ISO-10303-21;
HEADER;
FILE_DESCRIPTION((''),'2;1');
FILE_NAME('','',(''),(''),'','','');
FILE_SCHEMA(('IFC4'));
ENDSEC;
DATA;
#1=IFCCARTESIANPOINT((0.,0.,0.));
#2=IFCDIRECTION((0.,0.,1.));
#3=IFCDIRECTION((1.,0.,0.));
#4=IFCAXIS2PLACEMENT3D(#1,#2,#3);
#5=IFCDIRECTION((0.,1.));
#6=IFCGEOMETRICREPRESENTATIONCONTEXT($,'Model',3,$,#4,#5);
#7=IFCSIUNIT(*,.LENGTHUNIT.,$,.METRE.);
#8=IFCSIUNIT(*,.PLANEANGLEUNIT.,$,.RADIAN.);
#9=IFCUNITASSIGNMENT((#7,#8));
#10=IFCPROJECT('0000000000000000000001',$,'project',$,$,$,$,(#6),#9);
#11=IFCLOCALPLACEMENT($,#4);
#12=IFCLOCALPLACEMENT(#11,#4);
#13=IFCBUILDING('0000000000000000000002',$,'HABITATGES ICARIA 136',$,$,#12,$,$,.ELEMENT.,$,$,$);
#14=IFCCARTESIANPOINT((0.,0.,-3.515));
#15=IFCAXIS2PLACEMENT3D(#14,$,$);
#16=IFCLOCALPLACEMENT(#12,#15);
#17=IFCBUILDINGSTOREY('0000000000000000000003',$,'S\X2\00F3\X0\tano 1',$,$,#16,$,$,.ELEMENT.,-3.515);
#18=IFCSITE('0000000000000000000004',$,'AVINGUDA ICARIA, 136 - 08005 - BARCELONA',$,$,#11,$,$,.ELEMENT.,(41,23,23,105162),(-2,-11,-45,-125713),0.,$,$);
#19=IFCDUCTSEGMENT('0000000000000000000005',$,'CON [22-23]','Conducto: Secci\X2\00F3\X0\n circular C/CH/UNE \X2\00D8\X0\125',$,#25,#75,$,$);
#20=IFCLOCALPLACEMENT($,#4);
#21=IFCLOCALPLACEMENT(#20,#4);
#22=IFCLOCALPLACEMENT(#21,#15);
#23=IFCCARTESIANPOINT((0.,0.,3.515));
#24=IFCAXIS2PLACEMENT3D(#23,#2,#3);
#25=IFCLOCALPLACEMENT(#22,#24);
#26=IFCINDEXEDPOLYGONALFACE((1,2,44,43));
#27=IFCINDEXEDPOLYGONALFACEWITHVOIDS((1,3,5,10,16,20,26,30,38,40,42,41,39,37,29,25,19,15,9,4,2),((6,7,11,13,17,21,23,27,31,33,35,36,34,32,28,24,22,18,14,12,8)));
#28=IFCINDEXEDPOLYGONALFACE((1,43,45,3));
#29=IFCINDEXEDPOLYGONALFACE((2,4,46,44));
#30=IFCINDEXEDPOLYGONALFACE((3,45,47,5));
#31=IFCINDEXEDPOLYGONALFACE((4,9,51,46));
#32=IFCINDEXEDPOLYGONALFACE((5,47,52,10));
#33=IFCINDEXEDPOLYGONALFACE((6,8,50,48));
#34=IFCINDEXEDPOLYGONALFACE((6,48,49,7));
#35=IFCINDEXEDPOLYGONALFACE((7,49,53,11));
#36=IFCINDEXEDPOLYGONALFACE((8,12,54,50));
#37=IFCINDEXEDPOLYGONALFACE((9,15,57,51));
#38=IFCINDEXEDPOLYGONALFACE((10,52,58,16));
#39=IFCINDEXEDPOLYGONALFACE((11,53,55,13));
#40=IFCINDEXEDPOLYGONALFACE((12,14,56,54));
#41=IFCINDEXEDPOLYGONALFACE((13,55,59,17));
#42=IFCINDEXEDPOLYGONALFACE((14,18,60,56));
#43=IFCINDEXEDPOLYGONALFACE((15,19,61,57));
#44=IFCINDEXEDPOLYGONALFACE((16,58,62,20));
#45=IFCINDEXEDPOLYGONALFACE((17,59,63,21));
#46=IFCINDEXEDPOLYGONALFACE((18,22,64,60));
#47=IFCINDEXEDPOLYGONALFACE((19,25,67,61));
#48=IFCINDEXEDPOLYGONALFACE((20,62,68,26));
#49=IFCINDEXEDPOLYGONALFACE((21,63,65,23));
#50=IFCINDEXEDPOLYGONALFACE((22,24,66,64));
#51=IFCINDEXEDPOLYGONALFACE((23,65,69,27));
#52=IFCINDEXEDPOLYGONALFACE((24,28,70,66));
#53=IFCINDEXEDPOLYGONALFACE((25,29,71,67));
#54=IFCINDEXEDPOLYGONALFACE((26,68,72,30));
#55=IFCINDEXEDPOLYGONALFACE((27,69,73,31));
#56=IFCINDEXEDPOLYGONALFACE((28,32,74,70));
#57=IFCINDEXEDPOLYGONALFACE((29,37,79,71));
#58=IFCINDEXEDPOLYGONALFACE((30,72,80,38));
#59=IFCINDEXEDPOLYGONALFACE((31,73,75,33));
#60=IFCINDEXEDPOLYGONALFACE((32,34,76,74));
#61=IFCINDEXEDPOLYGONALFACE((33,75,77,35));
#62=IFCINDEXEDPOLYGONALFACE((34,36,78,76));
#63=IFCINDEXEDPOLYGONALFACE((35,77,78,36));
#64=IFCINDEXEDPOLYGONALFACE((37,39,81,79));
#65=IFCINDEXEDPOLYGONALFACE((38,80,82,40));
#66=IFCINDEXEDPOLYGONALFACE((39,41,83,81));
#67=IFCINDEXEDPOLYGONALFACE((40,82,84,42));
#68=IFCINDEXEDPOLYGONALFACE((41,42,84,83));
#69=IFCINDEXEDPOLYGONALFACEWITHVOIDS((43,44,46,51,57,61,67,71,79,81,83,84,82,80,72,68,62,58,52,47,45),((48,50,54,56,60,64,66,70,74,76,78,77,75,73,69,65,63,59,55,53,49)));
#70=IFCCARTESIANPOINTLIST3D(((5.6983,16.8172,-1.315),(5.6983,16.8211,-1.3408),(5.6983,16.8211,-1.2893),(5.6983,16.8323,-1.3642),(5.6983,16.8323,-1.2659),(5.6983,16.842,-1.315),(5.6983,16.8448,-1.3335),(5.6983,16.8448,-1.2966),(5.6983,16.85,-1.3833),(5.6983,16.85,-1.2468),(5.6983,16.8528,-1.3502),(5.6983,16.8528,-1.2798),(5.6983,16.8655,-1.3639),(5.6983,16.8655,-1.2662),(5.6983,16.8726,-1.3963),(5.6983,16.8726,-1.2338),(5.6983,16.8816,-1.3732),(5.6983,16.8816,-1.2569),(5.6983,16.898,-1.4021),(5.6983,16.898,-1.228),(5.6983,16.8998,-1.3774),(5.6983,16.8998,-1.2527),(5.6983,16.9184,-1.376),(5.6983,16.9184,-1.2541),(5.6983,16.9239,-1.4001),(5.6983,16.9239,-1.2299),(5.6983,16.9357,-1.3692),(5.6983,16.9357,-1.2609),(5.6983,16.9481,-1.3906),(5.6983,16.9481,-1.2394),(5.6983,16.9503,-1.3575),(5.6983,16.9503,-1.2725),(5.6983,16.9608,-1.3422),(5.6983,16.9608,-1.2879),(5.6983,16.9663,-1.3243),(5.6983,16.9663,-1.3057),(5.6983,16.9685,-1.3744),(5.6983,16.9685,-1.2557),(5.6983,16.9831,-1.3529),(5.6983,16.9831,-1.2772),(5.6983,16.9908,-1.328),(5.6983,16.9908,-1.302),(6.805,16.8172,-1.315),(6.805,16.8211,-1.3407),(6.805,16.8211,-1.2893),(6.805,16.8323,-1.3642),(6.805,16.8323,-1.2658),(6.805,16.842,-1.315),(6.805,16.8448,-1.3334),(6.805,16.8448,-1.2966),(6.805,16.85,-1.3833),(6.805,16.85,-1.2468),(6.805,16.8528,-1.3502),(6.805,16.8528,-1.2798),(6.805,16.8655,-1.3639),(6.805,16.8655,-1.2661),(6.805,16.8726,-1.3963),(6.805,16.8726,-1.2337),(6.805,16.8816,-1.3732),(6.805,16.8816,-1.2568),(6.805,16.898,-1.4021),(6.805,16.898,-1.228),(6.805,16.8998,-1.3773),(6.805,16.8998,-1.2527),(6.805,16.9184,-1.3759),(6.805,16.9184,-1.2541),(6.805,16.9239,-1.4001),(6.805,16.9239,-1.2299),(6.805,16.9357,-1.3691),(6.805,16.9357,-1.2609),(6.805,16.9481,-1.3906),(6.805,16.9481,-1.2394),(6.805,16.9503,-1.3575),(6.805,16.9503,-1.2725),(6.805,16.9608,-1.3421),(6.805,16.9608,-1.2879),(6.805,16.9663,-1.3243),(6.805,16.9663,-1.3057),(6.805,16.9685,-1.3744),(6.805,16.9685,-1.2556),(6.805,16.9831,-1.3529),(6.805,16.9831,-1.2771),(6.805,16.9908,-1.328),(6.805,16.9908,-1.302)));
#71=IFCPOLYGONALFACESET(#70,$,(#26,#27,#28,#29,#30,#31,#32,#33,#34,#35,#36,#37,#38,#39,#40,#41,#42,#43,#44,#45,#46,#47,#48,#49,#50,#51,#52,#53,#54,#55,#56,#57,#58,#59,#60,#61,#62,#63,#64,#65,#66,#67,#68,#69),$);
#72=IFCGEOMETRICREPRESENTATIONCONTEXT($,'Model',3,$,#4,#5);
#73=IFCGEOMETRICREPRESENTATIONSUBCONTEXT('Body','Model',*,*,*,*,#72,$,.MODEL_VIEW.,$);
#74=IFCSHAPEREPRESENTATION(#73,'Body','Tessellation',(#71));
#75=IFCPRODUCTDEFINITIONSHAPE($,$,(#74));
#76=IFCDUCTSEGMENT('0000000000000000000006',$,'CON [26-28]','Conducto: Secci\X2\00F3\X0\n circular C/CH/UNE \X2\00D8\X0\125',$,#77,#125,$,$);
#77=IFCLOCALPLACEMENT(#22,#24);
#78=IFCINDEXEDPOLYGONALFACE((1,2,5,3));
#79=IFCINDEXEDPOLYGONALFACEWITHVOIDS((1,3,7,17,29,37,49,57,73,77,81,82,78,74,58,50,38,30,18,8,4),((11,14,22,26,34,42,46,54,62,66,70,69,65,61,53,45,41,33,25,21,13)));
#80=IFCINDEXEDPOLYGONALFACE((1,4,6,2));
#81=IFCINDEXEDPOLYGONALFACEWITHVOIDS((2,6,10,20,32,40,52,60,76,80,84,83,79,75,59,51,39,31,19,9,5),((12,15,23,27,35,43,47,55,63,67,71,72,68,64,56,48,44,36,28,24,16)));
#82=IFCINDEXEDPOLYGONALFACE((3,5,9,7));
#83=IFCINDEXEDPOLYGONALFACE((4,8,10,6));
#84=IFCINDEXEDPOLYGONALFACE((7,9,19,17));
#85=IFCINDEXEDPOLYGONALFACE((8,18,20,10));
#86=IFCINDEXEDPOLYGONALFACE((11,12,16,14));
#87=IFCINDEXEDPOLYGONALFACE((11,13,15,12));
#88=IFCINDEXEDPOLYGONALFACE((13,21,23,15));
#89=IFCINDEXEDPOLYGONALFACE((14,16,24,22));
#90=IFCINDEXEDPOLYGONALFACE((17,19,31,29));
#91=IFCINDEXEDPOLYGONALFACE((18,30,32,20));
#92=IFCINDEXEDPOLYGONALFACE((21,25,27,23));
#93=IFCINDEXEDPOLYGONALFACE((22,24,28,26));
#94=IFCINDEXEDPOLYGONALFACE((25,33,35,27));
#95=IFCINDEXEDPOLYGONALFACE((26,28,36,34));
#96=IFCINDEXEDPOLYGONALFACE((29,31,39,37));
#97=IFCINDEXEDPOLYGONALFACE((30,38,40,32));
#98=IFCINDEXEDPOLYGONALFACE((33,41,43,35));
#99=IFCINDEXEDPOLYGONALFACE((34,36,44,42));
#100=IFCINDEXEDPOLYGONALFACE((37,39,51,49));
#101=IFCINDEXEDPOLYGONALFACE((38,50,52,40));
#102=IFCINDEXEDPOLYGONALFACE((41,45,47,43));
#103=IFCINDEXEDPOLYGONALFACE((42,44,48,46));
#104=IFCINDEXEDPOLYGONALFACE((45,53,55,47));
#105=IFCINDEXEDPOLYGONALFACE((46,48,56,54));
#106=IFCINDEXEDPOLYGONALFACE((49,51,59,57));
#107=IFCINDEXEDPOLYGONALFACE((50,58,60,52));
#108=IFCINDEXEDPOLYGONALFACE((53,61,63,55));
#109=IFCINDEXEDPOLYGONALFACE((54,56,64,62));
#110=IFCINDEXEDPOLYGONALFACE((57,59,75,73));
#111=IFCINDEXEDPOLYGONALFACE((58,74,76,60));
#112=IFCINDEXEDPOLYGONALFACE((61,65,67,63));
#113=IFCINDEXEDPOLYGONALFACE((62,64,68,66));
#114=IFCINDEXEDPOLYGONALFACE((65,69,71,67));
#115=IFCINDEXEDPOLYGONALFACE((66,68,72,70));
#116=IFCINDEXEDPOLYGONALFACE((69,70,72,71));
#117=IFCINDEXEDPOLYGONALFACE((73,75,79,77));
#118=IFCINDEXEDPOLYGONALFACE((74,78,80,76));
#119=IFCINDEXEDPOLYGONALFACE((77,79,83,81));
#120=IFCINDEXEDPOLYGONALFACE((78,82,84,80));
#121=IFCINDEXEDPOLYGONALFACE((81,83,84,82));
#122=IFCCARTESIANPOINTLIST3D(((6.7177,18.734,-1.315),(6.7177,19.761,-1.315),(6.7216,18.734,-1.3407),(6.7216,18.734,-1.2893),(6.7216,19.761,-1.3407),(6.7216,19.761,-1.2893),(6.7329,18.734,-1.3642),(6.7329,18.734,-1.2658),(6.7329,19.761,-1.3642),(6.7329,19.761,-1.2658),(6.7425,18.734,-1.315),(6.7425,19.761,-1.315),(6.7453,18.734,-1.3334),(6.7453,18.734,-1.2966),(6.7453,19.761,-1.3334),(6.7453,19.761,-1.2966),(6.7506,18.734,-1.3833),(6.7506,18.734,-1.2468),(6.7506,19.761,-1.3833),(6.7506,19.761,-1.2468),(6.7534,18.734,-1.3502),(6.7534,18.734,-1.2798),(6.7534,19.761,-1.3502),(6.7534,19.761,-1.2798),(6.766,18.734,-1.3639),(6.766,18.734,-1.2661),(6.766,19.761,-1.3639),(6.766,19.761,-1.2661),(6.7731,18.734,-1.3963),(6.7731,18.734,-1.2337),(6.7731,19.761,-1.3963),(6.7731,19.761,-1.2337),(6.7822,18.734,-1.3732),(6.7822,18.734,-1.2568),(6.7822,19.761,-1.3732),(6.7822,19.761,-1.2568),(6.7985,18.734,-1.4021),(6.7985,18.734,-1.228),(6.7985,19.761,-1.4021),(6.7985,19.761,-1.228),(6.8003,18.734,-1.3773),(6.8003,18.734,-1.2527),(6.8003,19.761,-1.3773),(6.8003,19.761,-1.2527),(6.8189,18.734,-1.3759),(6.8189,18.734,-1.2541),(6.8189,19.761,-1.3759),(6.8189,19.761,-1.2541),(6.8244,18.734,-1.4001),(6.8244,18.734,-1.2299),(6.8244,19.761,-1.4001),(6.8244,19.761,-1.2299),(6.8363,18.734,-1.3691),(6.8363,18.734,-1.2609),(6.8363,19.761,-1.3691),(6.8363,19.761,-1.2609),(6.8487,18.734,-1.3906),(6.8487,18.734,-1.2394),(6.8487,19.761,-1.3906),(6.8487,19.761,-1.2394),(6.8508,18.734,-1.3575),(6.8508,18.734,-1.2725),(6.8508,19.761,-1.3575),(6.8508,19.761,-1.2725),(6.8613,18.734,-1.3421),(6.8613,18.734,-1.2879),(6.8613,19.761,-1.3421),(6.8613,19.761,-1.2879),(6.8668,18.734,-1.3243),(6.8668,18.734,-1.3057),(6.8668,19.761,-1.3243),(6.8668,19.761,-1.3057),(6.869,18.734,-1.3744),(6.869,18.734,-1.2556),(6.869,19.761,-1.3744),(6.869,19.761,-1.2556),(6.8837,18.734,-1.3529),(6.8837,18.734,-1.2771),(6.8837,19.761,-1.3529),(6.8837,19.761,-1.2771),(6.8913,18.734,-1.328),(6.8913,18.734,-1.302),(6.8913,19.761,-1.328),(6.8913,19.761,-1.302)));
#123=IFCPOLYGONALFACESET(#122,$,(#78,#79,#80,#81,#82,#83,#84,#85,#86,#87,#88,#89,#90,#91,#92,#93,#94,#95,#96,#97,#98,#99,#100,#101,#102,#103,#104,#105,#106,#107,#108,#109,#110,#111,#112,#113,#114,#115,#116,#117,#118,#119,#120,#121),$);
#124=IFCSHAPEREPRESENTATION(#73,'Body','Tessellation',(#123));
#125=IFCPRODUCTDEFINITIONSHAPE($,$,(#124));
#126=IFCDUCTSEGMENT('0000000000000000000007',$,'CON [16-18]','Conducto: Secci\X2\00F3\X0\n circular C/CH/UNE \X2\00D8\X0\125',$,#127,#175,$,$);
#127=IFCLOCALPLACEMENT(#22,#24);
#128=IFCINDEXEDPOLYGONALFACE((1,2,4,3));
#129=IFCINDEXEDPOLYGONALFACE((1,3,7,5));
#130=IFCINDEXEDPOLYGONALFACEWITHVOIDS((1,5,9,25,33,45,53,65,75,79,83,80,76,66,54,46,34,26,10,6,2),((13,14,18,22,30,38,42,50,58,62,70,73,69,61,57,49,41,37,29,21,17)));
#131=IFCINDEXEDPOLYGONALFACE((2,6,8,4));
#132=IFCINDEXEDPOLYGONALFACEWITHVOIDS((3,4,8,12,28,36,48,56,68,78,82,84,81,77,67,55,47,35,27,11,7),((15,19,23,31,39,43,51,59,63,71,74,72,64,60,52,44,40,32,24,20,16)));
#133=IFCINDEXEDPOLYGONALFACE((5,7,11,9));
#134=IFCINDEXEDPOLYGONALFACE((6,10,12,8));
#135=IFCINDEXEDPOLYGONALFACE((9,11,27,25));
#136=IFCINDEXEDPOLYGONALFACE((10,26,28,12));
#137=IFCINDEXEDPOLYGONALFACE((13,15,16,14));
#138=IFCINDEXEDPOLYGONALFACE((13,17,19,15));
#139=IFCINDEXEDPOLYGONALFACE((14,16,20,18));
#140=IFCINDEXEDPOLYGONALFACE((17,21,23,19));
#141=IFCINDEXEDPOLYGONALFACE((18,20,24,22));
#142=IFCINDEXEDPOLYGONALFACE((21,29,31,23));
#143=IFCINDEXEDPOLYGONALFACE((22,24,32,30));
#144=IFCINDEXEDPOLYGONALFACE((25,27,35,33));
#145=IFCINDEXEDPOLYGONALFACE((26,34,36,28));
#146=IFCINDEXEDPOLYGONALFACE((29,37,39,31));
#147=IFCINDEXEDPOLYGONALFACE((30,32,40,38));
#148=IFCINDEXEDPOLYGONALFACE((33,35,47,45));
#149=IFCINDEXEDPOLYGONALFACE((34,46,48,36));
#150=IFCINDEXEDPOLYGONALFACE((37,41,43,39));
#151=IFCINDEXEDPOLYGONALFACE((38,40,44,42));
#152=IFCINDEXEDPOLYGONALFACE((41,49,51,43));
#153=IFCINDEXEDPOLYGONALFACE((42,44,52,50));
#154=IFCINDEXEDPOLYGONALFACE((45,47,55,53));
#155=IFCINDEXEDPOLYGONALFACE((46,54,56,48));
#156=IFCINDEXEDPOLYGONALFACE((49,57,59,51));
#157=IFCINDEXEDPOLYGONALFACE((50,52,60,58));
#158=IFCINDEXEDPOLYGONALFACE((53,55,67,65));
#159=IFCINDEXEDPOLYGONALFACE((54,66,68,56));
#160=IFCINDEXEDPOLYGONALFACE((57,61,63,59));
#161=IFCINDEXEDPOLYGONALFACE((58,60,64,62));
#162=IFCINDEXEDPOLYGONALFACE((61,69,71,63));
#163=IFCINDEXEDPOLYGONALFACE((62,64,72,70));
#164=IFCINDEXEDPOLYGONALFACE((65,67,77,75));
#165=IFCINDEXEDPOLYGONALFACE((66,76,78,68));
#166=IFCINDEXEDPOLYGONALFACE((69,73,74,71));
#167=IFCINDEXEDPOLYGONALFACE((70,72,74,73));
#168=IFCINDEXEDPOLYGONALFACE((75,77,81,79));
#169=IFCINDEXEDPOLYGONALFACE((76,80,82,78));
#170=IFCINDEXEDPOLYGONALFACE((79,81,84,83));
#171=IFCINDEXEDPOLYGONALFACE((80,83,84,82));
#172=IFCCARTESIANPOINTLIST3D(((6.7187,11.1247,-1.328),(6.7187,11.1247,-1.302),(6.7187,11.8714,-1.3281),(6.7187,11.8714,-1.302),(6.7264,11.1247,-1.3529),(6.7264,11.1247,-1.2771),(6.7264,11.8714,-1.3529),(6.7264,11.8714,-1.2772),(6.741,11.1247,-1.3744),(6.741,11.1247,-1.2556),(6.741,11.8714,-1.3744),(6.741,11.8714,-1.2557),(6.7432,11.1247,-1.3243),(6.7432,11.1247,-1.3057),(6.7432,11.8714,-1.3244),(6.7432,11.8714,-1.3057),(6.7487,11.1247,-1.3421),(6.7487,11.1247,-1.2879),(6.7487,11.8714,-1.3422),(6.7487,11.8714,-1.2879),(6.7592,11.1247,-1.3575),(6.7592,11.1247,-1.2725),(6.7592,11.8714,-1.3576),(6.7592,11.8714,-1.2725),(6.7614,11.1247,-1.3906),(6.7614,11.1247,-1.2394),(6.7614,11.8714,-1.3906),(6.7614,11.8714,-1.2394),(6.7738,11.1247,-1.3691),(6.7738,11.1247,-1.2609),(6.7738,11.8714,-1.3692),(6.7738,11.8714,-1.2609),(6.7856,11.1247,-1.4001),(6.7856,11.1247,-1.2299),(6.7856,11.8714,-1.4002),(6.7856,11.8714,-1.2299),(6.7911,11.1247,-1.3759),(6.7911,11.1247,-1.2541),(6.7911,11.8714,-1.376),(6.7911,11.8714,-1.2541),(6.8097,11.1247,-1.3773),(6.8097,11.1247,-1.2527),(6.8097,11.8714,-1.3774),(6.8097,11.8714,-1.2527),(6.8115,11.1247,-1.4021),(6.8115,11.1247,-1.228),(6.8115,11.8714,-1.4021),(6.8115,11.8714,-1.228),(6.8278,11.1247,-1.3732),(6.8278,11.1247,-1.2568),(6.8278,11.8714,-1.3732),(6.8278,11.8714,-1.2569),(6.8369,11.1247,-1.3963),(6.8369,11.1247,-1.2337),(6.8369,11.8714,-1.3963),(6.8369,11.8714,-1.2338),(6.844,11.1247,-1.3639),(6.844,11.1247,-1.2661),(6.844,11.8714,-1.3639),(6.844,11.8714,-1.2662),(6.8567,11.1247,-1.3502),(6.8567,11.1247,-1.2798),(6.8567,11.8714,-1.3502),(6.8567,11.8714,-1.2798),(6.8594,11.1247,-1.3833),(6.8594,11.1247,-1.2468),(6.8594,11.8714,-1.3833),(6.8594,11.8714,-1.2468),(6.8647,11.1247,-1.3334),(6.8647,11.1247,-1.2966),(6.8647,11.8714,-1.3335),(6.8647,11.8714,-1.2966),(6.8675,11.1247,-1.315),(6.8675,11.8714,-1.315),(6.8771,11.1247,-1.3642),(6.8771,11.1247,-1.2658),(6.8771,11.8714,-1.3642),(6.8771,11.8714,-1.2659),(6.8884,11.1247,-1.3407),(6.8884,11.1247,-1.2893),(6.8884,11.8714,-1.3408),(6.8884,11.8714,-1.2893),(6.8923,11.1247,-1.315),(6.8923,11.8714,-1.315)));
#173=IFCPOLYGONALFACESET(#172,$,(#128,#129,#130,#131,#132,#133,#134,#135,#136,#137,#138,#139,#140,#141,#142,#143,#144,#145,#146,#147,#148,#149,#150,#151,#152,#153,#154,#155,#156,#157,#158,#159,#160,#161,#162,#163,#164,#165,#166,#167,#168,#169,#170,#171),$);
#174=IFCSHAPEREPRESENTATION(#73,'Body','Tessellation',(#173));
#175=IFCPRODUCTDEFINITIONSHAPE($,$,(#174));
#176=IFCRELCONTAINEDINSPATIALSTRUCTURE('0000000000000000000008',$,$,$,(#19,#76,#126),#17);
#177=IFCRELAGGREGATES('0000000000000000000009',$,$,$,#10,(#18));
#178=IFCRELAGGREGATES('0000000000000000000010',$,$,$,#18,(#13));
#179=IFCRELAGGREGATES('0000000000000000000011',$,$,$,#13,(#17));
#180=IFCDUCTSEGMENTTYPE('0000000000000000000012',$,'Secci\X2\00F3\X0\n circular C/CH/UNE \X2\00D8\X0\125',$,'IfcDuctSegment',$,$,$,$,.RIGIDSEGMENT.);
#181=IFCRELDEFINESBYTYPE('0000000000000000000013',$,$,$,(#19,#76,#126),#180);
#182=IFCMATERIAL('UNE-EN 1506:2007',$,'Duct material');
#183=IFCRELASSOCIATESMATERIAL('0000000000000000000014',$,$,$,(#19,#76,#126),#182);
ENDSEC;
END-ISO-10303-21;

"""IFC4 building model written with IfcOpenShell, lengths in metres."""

from ifc_helpers import new_model, si_unit, direction, frame, origin_with_axes, origin_2d_with_axis, place, context, subcontext, project, spatial, hollow_circle, extrude, material, type_object, element, save


model = new_model("IFC4")

# Units and contexts
model_context_1 = context("Model", 3, world=origin_with_axes(), true_north=direction((0.0, 1.0)))
model_context_2 = context("Model", 3, world=origin_with_axes(), true_north=direction((0.0, 1.0)))
body_context_1 = subcontext(model_context_2, "Body", "Model", "MODEL_VIEW")
ifc_project = project(units=[si_unit("LENGTHUNIT", "METRE"), si_unit("PLANEANGLEUNIT", "RADIAN")], contexts=[model_context_1])

# Site, building, storey
site_placement = place(None, origin_with_axes())
site = spatial("IfcSite", under=ifc_project, at=site_placement, Name="AVINGUDA ICARIA, 136 - 08005 - BARCELONA", CompositionType="ELEMENT", RefLatitude=(41, 23, 23, 105162), RefLongitude=(-2, -11, -45, -125713), RefElevation=0.0)
building_placement = place(site_placement, origin_with_axes())
building = spatial("IfcBuilding", under=site, at=building_placement, Name="HABITATGES ICARIA 136", CompositionType="ELEMENT")
storey_placement = place(building_placement, frame((0.0, 0.0, -3.515)))
storey = spatial("IfcBuildingStorey", under=building, at=storey_placement, Name="Sótano 1", CompositionType="ELEMENT", Elevation=-3.515)

# Duct segments
ifc_material_1 = material(Name="UNE-EN 1506:2007", Category="Duct material")
duct_segment_type = type_object("IfcDuctSegmentType", Name="Sección circular C/CH/UNE Ø125", ApplicableOccurrence="IfcDuctSegment", PredefinedType="RIGIDSEGMENT")
placement_1 = place(None, origin_with_axes())
placement_2 = place(placement_1, origin_with_axes())
placement_3 = place(placement_2, frame((0.0, 0.0, -3.515)))
duct_segment_1_placement = place(placement_3, frame((0.0, 0.0, 3.515), z_axis=(0.0, 0.0, 1.0), x_axis=(1.0, 0.0, 0.0)))
element("IfcDuctSegment", 1, at=duct_segment_1_placement, inside=storey, type_object=duct_segment_type, material=ifc_material_1, Name="CON [22-23]", Description="Conducto: Sección circular C/CH/UNE Ø125", context=body_context_1, shape_type="SweptSolid", body=[
    extrude(hollow_circle(Radius=0.0873, WallThickness=0.0248, at=origin_2d_with_axis()), frame((6.805, 16.9045, -1.315), z_axis=(-1.0, 0.0, -0.000017), x_axis=(0.0, -1.0, 0.0)), (0.0, 0.0, 1.0), 1.1067),
])
duct_segment_2_placement = place(placement_3, frame((0.0, 0.0, 3.515), z_axis=(0.0, 0.0, 1.0), x_axis=(1.0, 0.0, 0.0)))
element("IfcDuctSegment", 2, at=duct_segment_2_placement, inside=storey, type_object=duct_segment_type, material=ifc_material_1, Name="CON [26-28]", Description="Conducto: Sección circular C/CH/UNE Ø125", context=body_context_1, shape_type="SweptSolid", body=[
    extrude(hollow_circle(Radius=0.0873, WallThickness=0.0248, at=origin_2d_with_axis()), frame((6.805, 18.734, -1.315), z_axis=(0.0, 1.0, 0.0), x_axis=(-1.0, 0.0, 0.0)), (0.0, 0.0, 1.0), 1.027),
])
duct_segment_3_placement = place(placement_3, frame((0.0, 0.0, 3.515), z_axis=(0.0, 0.0, 1.0), x_axis=(1.0, 0.0, 0.0)))
element("IfcDuctSegment", 3, at=duct_segment_3_placement, inside=storey, type_object=duct_segment_type, material=ifc_material_1, Name="CON [16-18]", Description="Conducto: Sección circular C/CH/UNE Ø125", context=body_context_1, shape_type="SweptSolid", body=[
    extrude(hollow_circle(Radius=0.0873, WallThickness=0.0248, at=origin_2d_with_axis()), frame((6.805, 11.8714, -1.315), z_axis=(0.0, -1.0, 0.000045), x_axis=(1.0, 0.0, 0.0)), (0.0, 0.0, 1.0), 0.7467),
])

save(model, "model.ifc")
